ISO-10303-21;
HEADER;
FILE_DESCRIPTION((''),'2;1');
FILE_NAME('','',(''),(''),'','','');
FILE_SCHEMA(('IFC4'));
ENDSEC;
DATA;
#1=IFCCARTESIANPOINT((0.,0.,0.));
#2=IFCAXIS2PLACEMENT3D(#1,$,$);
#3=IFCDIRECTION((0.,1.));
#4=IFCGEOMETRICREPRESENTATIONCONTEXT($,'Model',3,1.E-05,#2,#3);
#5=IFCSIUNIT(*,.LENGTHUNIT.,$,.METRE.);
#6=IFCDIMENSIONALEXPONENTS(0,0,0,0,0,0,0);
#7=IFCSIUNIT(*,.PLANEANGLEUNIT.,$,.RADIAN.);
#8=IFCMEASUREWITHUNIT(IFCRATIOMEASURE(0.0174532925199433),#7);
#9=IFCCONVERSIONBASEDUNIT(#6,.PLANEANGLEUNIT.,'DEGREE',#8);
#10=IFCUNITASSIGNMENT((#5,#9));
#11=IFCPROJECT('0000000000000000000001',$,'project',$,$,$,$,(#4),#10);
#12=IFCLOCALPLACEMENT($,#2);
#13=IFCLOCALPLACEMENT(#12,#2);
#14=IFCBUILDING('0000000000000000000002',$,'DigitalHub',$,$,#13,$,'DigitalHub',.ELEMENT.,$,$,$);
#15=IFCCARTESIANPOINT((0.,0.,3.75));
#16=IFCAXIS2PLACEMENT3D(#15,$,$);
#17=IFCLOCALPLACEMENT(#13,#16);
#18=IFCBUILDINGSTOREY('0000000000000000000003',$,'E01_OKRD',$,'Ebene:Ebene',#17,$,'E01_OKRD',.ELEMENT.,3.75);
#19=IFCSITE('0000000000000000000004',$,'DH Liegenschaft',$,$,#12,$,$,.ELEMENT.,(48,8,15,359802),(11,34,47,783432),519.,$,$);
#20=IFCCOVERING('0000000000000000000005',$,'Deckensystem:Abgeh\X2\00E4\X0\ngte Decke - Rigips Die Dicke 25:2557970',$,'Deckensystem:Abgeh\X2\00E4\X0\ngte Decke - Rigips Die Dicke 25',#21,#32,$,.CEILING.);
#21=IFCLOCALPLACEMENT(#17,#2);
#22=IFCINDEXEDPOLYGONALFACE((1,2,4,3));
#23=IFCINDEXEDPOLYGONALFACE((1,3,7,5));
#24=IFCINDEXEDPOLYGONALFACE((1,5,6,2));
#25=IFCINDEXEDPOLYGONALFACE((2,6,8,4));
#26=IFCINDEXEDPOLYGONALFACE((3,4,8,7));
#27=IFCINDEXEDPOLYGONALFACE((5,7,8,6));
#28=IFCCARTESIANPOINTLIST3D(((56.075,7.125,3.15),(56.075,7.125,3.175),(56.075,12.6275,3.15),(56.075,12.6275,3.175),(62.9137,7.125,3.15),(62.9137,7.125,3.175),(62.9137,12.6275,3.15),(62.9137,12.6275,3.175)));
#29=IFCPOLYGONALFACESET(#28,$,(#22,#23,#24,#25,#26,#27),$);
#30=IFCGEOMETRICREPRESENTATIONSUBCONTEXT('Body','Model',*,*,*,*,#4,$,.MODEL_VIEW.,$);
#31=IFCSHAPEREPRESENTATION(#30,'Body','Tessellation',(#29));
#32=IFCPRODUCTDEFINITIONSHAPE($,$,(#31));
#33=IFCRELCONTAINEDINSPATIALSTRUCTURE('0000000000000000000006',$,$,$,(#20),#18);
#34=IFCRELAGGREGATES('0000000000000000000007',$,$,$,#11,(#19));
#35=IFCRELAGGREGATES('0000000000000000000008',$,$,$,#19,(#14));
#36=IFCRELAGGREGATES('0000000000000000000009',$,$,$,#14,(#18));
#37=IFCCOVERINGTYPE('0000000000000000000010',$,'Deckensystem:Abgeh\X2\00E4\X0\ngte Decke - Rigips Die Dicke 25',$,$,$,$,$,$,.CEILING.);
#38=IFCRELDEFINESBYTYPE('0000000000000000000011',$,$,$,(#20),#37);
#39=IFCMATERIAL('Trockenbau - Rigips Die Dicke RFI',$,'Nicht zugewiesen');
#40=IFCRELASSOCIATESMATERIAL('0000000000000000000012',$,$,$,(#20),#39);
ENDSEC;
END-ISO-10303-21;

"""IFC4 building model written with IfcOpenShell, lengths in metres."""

from ifc_helpers import new_model, entity, si_unit, converted_unit, direction, frame, origin, place, context, subcontext, project, spatial, indexed_curve, outline, extrude, material, type_object, element, save


model = new_model("IFC4")

# Units and contexts
model_context = context("Model", 3, precision=1e-05, world=origin(), true_north=direction((0.0, 1.0)))
body_context = subcontext(model_context, "Body", "Model", "MODEL_VIEW")
ifc_project = project(units=[si_unit("LENGTHUNIT", "METRE"), converted_unit("PLANEANGLEUNIT", "DEGREE", entity("IfcRatioMeasure", 0.0174532925199433), si_unit("PLANEANGLEUNIT", "RADIAN"), dimensions=[0, 0, 0, 0, 0, 0, 0])], contexts=[model_context])

# Site, building, storey
site_placement = place(None, frame((0.0, 0.0, 0.0)))
site = spatial("IfcSite", under=ifc_project, at=site_placement, Name="DH Liegenschaft", CompositionType="ELEMENT", RefLatitude=(48, 8, 15, 359802), RefLongitude=(11, 34, 47, 783432), RefElevation=519.0)
building_placement = place(site_placement, origin())
building = spatial("IfcBuilding", under=site, at=building_placement, Name="DigitalHub", LongName="DigitalHub", CompositionType="ELEMENT")
storey_placement = place(building_placement, frame((0.0, 0.0, 3.75)))
storey = spatial("IfcBuildingStorey", under=building, at=storey_placement, Name="E01_OKRD", ObjectType="Ebene:Ebene", LongName="E01_OKRD", CompositionType="ELEMENT", Elevation=3.75)

# Covering
ifc_material_1 = material(Name="Trockenbau - Rigips Die Dicke RFI", Category="Nicht zugewiesen")
covering_type_1 = type_object("IfcCoveringType", Name="Deckensystem:Abgehängte Decke - Rigips Die Dicke 25", PredefinedType="CEILING")
covering_1_placement = place(storey_placement, frame((56.075, 7.125, 3.15)))
element("IfcCovering", 1, at=covering_1_placement, inside=storey, type_object=covering_type_1, material=ifc_material_1, Name="Deckensystem:Abgehängte Decke - Rigips Die Dicke 25:2557970", ObjectType="Deckensystem:Abgehängte Decke - Rigips Die Dicke 25", PredefinedType="CEILING", context=body_context, shape_type="SweptSolid", body=[
    extrude(outline(indexed_curve([(-3.4194, -2.7512), (3.4194, -2.7512), (3.4194, 2.7512), (-3.4194, 2.7512), (-3.4194, -2.7512)], self_intersect=False)), frame((3.4194, 2.7512, 0.0), z_axis=(0.0, 0.0, 1.0), x_axis=(-1.0, 0.0, 0.0)), (0.0, 0.0, 1.0), 0.025),
])

save(model, "model.ifc")
